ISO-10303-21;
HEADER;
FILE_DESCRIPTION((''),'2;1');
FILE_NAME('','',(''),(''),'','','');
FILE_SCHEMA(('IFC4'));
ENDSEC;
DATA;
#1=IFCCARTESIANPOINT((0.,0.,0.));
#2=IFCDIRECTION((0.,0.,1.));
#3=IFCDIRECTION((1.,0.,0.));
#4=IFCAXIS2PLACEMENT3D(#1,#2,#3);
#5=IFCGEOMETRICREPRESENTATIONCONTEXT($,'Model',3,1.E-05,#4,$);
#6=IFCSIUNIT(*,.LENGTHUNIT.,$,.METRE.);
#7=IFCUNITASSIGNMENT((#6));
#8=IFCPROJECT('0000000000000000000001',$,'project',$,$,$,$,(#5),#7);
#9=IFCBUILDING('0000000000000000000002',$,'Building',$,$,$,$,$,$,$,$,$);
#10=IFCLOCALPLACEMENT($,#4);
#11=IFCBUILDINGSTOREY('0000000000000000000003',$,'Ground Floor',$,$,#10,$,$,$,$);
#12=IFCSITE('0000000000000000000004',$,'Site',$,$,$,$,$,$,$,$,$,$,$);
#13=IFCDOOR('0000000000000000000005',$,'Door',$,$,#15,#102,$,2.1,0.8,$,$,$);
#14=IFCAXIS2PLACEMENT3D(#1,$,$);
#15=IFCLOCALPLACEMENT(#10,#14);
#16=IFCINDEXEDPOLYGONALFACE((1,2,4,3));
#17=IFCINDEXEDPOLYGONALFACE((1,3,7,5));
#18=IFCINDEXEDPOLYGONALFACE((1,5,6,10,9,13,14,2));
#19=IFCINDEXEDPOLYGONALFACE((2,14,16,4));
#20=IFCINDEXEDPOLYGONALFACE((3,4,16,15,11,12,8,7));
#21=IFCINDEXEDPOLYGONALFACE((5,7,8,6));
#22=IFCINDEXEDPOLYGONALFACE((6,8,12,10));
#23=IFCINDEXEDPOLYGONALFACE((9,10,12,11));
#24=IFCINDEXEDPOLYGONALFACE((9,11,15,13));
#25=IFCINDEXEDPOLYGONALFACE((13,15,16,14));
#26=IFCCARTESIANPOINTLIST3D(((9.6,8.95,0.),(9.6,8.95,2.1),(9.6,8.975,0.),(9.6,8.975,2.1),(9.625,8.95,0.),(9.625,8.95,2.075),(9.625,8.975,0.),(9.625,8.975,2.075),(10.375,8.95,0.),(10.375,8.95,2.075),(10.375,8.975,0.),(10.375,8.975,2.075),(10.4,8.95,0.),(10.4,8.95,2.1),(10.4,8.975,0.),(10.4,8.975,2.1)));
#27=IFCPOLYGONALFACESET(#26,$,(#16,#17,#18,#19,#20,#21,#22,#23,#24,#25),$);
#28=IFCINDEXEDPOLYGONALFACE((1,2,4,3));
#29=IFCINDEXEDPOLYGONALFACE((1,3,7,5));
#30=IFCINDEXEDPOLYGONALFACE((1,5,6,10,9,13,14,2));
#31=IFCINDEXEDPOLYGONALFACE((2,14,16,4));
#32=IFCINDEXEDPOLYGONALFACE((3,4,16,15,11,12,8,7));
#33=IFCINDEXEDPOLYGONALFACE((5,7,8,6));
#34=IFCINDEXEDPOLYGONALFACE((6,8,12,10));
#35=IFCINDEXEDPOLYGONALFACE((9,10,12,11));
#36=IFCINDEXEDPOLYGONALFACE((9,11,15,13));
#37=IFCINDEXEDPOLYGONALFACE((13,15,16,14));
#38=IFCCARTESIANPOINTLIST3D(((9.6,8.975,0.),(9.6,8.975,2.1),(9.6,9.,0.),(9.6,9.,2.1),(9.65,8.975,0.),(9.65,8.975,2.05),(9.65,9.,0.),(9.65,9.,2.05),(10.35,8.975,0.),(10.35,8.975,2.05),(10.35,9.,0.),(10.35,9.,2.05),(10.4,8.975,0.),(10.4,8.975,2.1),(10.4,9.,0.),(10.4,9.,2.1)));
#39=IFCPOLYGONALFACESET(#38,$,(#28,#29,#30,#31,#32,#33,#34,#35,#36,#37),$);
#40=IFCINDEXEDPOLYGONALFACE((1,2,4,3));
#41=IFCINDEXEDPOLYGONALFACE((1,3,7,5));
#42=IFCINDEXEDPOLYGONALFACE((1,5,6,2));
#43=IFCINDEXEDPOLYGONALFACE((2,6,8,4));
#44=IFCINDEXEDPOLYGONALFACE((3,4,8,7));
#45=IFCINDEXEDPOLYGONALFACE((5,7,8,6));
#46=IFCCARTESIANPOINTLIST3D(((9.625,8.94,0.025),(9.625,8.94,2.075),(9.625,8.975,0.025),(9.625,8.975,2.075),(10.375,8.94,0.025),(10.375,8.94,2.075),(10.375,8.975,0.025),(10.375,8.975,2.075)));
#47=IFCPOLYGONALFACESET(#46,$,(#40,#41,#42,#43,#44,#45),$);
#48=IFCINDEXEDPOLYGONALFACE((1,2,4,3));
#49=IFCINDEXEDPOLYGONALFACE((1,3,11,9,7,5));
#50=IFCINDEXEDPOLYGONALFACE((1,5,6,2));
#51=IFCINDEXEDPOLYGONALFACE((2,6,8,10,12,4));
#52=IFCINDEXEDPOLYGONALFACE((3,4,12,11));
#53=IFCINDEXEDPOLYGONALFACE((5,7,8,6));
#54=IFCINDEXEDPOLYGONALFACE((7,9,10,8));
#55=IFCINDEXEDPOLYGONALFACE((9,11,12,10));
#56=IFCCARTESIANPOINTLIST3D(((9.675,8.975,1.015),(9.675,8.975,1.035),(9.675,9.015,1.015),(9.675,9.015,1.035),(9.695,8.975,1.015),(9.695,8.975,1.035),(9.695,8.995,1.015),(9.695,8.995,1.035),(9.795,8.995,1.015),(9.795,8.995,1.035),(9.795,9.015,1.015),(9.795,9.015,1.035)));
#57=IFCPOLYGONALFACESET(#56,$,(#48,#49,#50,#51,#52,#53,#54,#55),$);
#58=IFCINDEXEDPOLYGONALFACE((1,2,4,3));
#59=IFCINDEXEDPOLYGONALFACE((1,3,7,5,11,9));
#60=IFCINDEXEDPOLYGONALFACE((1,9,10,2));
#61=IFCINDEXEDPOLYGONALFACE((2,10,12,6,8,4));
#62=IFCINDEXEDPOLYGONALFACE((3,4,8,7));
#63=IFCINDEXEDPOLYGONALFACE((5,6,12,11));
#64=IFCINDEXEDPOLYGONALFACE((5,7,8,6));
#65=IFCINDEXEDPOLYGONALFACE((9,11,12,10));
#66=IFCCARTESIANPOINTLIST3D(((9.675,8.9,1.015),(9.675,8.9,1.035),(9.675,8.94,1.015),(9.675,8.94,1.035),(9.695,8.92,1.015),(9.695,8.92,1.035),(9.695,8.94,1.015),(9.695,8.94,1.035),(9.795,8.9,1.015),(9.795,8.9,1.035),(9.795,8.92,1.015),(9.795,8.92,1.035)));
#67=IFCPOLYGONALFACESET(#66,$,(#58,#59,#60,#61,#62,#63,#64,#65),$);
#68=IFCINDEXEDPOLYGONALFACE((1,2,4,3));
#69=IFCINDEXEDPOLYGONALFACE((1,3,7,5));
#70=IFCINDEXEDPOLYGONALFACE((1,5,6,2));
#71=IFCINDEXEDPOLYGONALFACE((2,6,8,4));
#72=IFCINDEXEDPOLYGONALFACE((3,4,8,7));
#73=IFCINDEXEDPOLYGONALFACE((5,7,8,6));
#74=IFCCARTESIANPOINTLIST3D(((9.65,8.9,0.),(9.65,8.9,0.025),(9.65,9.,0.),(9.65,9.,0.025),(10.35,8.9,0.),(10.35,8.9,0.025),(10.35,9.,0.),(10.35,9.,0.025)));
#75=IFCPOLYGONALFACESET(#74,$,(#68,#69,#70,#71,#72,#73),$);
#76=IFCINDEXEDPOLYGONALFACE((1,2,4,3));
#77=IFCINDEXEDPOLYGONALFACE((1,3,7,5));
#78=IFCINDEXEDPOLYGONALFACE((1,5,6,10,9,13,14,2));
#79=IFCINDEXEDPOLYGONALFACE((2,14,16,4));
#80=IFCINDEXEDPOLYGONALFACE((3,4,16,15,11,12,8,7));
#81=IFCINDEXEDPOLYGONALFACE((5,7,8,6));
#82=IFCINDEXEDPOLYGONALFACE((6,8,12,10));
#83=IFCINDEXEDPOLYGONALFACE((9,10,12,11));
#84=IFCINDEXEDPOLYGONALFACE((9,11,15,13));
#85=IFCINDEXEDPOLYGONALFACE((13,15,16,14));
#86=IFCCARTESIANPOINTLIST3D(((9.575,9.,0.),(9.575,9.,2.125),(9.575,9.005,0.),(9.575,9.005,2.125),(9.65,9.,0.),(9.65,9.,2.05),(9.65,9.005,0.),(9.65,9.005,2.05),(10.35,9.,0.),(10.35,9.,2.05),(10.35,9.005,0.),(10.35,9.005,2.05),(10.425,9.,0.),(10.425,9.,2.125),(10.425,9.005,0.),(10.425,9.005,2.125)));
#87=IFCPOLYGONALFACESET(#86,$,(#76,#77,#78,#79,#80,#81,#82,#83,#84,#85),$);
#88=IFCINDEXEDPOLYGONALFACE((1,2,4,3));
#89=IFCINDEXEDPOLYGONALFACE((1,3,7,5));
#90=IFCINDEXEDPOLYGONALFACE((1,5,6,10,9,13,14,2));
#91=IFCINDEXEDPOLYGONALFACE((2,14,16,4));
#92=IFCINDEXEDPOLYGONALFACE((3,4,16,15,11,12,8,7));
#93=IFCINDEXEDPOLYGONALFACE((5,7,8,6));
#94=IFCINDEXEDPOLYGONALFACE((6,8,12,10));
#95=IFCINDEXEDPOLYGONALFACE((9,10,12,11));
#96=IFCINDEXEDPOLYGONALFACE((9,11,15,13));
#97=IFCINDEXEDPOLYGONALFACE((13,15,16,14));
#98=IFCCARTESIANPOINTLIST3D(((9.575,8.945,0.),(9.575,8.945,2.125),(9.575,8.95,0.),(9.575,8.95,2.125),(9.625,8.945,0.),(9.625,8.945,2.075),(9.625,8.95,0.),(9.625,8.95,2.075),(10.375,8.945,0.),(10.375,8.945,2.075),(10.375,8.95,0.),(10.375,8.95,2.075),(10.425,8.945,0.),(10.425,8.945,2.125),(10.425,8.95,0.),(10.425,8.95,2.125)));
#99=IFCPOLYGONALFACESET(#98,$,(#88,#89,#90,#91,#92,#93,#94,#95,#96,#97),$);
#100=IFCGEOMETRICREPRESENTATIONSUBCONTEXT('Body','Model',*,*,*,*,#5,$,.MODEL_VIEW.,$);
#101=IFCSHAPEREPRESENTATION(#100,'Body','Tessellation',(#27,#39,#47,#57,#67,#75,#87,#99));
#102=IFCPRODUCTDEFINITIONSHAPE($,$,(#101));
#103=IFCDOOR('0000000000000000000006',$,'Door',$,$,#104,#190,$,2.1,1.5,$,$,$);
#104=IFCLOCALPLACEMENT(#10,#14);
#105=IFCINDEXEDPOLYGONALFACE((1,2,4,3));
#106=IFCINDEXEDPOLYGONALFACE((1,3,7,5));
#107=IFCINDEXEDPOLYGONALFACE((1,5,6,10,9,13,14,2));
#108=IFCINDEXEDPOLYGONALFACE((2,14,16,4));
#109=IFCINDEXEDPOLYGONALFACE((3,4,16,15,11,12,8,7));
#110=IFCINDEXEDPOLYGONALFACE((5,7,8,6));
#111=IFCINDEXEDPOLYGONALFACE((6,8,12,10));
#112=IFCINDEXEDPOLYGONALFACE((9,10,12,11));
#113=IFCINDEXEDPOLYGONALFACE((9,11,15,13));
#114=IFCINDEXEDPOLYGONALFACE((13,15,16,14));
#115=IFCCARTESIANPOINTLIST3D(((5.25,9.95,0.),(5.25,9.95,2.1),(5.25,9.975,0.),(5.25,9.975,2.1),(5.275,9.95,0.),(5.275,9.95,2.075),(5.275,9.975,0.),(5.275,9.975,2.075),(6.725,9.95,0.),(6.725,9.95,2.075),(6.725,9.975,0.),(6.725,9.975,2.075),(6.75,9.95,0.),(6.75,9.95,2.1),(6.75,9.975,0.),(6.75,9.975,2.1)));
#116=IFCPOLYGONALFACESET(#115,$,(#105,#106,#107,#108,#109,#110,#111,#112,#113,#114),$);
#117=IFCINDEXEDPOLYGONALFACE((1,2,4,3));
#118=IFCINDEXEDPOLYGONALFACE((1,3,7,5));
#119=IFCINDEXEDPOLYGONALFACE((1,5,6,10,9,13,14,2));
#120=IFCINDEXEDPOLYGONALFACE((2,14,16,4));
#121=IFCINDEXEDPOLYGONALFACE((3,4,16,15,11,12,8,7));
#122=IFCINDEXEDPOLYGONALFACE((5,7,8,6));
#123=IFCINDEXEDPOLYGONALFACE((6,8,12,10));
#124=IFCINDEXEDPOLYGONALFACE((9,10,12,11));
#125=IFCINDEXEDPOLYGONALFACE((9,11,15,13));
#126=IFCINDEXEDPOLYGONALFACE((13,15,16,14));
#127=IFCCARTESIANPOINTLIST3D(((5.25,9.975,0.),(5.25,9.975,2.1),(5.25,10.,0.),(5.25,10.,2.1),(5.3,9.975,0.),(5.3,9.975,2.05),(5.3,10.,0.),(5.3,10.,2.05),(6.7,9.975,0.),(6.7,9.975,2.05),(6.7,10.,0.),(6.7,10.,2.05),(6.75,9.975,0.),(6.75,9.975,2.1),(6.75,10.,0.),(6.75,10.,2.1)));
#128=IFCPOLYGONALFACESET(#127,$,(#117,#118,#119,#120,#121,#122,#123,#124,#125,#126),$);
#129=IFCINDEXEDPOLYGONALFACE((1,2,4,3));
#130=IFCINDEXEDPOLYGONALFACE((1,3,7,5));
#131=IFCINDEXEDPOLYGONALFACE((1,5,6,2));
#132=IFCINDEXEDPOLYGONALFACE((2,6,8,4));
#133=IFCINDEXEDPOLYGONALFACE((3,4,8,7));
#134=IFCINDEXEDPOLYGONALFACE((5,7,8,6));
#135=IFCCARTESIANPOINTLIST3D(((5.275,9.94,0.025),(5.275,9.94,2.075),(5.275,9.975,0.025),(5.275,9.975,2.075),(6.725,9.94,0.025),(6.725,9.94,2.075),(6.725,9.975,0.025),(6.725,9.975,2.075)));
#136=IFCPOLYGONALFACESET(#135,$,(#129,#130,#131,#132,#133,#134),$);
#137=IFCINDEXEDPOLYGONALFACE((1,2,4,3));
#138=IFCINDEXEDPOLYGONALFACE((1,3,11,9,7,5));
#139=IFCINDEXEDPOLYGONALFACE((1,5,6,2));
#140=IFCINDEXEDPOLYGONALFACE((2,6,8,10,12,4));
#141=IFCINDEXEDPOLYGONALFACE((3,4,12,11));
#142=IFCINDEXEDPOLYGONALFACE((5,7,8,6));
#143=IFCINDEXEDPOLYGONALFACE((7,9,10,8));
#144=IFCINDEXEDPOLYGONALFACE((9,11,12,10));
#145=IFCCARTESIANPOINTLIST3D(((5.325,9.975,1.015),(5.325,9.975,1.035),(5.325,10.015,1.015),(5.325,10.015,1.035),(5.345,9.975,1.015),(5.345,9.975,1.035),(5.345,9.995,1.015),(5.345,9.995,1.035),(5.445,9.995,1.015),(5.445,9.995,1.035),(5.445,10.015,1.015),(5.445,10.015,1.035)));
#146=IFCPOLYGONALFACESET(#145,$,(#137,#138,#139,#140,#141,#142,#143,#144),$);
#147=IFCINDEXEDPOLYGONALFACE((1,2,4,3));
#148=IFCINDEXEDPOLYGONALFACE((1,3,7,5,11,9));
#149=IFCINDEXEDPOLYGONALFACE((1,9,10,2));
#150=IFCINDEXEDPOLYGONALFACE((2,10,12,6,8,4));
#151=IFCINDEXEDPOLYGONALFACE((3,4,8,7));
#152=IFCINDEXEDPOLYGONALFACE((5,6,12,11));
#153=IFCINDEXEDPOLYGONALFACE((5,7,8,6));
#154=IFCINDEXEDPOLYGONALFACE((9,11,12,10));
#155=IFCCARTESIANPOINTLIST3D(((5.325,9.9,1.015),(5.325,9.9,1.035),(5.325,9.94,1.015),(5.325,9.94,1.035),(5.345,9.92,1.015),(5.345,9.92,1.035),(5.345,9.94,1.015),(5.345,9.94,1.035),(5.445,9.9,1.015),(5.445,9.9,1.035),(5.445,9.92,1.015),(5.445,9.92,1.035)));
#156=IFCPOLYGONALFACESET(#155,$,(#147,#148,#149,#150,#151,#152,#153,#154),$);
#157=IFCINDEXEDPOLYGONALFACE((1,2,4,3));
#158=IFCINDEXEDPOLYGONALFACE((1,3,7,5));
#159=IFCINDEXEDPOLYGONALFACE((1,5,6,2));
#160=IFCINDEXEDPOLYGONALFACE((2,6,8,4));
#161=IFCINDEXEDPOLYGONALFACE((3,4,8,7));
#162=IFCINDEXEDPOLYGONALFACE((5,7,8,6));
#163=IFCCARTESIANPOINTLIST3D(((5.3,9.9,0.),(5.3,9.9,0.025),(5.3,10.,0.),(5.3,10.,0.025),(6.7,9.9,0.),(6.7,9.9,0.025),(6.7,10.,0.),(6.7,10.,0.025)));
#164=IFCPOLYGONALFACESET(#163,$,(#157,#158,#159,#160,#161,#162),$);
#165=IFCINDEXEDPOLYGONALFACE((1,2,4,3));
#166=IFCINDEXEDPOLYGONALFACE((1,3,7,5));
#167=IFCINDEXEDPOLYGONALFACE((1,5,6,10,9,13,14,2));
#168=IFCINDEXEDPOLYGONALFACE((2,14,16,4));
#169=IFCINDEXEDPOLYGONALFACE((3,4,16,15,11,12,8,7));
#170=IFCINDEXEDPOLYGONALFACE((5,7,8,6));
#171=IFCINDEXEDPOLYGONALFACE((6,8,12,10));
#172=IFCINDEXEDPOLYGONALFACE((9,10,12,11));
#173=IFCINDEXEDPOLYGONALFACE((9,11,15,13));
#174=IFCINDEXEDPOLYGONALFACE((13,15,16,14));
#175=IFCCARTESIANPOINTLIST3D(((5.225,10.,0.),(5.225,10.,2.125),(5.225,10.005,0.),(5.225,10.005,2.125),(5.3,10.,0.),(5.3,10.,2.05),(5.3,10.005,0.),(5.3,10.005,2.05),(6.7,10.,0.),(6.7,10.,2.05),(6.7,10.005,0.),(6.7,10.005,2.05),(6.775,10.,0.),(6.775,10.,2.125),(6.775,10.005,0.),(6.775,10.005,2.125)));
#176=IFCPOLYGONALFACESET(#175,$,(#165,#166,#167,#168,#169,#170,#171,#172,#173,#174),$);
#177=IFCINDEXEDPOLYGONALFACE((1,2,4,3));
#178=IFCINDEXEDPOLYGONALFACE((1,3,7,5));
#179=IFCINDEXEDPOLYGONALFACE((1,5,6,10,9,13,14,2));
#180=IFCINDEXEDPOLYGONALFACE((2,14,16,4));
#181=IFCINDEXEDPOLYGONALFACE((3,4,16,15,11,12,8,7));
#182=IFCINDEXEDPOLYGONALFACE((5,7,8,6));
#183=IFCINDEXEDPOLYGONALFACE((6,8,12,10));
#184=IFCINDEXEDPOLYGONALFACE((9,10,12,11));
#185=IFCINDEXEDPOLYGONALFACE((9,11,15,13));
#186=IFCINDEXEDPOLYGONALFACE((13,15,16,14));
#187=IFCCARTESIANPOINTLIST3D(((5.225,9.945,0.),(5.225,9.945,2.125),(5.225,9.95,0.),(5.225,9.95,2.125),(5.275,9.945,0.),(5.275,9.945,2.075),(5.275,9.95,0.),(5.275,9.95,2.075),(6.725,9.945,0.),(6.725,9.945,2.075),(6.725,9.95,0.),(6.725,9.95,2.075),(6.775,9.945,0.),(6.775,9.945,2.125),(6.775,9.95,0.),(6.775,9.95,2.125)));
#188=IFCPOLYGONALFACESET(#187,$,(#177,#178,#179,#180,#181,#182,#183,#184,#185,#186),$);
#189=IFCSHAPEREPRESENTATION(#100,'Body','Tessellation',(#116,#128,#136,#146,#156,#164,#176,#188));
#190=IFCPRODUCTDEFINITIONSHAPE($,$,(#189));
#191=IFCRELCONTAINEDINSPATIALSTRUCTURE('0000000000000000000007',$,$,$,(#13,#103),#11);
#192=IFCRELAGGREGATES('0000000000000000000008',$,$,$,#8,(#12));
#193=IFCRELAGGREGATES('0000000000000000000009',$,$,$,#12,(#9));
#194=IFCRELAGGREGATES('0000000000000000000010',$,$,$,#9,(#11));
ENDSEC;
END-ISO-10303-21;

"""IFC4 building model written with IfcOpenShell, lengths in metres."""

from ifc_helpers import new_model, si_unit, frame, origin_with_axes, place, context, subcontext, project, spatial, line, indexed_curve, outline, extrude, element, save


model = new_model("IFC4")

# Units and contexts
model_context = context("Model", 3, precision=1e-05, world=origin_with_axes())
body_context = subcontext(model_context, "Body", "Model", "MODEL_VIEW")
ifc_project = project(units=[si_unit("LENGTHUNIT", "METRE")], contexts=[model_context])

# Site, building, storey
site = spatial("IfcSite", under=ifc_project, Name="Site")
building = spatial("IfcBuilding", under=site, Name="Building")
storey_placement = place(None, origin_with_axes())
storey = spatial("IfcBuildingStorey", under=building, at=storey_placement, Name="Ground Floor")

# Doors
door_1_placement = place(storey_placement, frame((10.4, 9.0, 0.0), z_axis=(0.0, 0.0, 1.0), x_axis=(-1.0, 0.0, 0.0)))
element("IfcDoor", 1, at=door_1_placement, inside=storey, Name="Door", OverallHeight=2.1, OverallWidth=0.8, context=body_context, shape_type="SweptSolid", body=[
    extrude(outline(indexed_curve([(0.0, 0.0), (0.0, 2.1), (0.8, 2.1), (0.8, 0.0), (0.775, 0.0), (0.775, 2.075), (0.025, 2.075), (0.025, 0.0)], segments=[line(1, 2, 3, 4, 5, 6, 7, 8, 1)])), frame((0.0, 0.025, 0.0), z_axis=(0.0, -1.0, 0.0), x_axis=(1.0, 0.0, 0.0)), (0.0, 0.0, -1.0), 0.025),
    extrude(outline(indexed_curve([(0.0, 0.0), (0.0, 2.1), (0.8, 2.1), (0.8, 0.0), (0.75, 0.0), (0.75, 2.05), (0.05, 2.05), (0.05, 0.0)], segments=[line(1, 2, 3, 4, 5, 6, 7, 8, 1)])), frame((0.0, 0.0, 0.0), z_axis=(0.0, -1.0, 0.0), x_axis=(1.0, 0.0, 0.0)), (0.0, 0.0, -1.0), 0.025),
    extrude(outline(indexed_curve([(0.0, 0.0), (0.75, 0.0), (0.75, 0.035), (0.0, 0.035)], segments=[line(1, 2, 3, 4, 1)])), frame((0.025, 0.025, 0.025), z_axis=(0.0, 0.0, 1.0), x_axis=(1.0, 0.0, 0.0)), (0.0, 0.0, 1.0), 2.05),
    extrude(outline(indexed_curve([(0.0, 0.0), (0.0, -0.04), (-0.12, -0.04), (-0.12, -0.02), (-0.02, -0.02), (-0.02, 0.0)], segments=[line(1, 2, 3, 4, 5, 6, 1)])), frame((0.725, 0.025, 1.015), z_axis=(0.0, 0.0, 1.0), x_axis=(1.0, 0.0, 0.0)), (0.0, 0.0, 1.0), 0.02),
    extrude(outline(indexed_curve([(0.0, 0.0), (0.0, 0.04), (-0.12, 0.04), (-0.12, 0.02), (-0.02, 0.02), (-0.02, 0.0)], segments=[line(1, 2, 3, 4, 5, 6, 1)])), frame((0.725, 0.06, 1.015), z_axis=(0.0, 0.0, 1.0), x_axis=(1.0, 0.0, 0.0)), (0.0, 0.0, 1.0), 0.02),
    extrude(outline(indexed_curve([(0.0, 0.0), (0.7, 0.0), (0.7, 0.1), (0.0, 0.1)], segments=[line(1, 2, 3, 4, 1)])), frame((0.05, 0.0, 0.0), z_axis=(0.0, 0.0, 1.0), x_axis=(1.0, 0.0, 0.0)), (0.0, 0.0, 1.0), 0.025),
    extrude(outline(indexed_curve([(0.0, 0.0), (0.0, 2.125), (0.85, 2.125), (0.85, 0.0), (0.775, 0.0), (0.775, 2.05), (0.075, 2.05), (0.075, 0.0)], segments=[line(1, 2, 3, 4, 5, 6, 7, 8, 1)])), frame((-0.025, -0.005, 0.0), z_axis=(0.0, -1.0, 0.0), x_axis=(1.0, 0.0, 0.0)), (0.0, 0.0, -1.0), 0.005),
    extrude(outline(indexed_curve([(0.0, 0.0), (0.0, 2.125), (0.85, 2.125), (0.85, 0.0), (0.8, 0.0), (0.8, 2.075), (0.05, 2.075), (0.05, 0.0)], segments=[line(1, 2, 3, 4, 5, 6, 7, 8, 1)])), frame((-0.025, 0.05, 0.0), z_axis=(0.0, -1.0, 0.0), x_axis=(1.0, 0.0, 0.0)), (0.0, 0.0, -1.0), 0.005),
])
door_2_placement = place(storey_placement, frame((6.75, 10.0, 0.0), z_axis=(0.0, 0.0, 1.0), x_axis=(-1.0, 0.0, 0.0)))
element("IfcDoor", 2, at=door_2_placement, inside=storey, Name="Door", OverallHeight=2.1, OverallWidth=1.5, context=body_context, shape_type="SweptSolid", body=[
    extrude(outline(indexed_curve([(0.0, 0.0), (0.0, 2.1), (1.5, 2.1), (1.5, 0.0), (1.475, 0.0), (1.475, 2.075), (0.025, 2.075), (0.025, 0.0)], segments=[line(1, 2, 3, 4, 5, 6, 7, 8, 1)])), frame((0.0, 0.025, 0.0), z_axis=(0.0, -1.0, 0.0), x_axis=(1.0, 0.0, 0.0)), (0.0, 0.0, -1.0), 0.025),
    extrude(outline(indexed_curve([(0.0, 0.0), (0.0, 2.1), (1.5, 2.1), (1.5, 0.0), (1.45, 0.0), (1.45, 2.05), (0.05, 2.05), (0.05, 0.0)], segments=[line(1, 2, 3, 4, 5, 6, 7, 8, 1)])), frame((0.0, 0.0, 0.0), z_axis=(0.0, -1.0, 0.0), x_axis=(1.0, 0.0, 0.0)), (0.0, 0.0, -1.0), 0.025),
    extrude(outline(indexed_curve([(0.0, 0.0), (1.45, 0.0), (1.45, 0.035), (0.0, 0.035)], segments=[line(1, 2, 3, 4, 1)])), frame((0.025, 0.025, 0.025), z_axis=(0.0, 0.0, 1.0), x_axis=(1.0, 0.0, 0.0)), (0.0, 0.0, 1.0), 2.05),
    extrude(outline(indexed_curve([(0.0, 0.0), (0.0, -0.04), (-0.12, -0.04), (-0.12, -0.02), (-0.02, -0.02), (-0.02, 0.0)], segments=[line(1, 2, 3, 4, 5, 6, 1)])), frame((1.425, 0.025, 1.015), z_axis=(0.0, 0.0, 1.0), x_axis=(1.0, 0.0, 0.0)), (0.0, 0.0, 1.0), 0.02),
    extrude(outline(indexed_curve([(0.0, 0.0), (0.0, 0.04), (-0.12, 0.04), (-0.12, 0.02), (-0.02, 0.02), (-0.02, 0.0)], segments=[line(1, 2, 3, 4, 5, 6, 1)])), frame((1.425, 0.06, 1.015), z_axis=(0.0, 0.0, 1.0), x_axis=(1.0, 0.0, 0.0)), (0.0, 0.0, 1.0), 0.02),
    extrude(outline(indexed_curve([(0.0, 0.0), (1.4, 0.0), (1.4, 0.1), (0.0, 0.1)], segments=[line(1, 2, 3, 4, 1)])), frame((0.05, 0.0, 0.0), z_axis=(0.0, 0.0, 1.0), x_axis=(1.0, 0.0, 0.0)), (0.0, 0.0, 1.0), 0.025),
    extrude(outline(indexed_curve([(0.0, 0.0), (0.0, 2.125), (1.55, 2.125), (1.55, 0.0), (1.475, 0.0), (1.475, 2.05), (0.075, 2.05), (0.075, 0.0)], segments=[line(1, 2, 3, 4, 5, 6, 7, 8, 1)])), frame((-0.025, -0.005, 0.0), z_axis=(0.0, -1.0, 0.0), x_axis=(1.0, 0.0, 0.0)), (0.0, 0.0, -1.0), 0.005),
    extrude(outline(indexed_curve([(0.0, 0.0), (0.0, 2.125), (1.55, 2.125), (1.55, 0.0), (1.5, 0.0), (1.5, 2.075), (0.05, 2.075), (0.05, 0.0)], segments=[line(1, 2, 3, 4, 5, 6, 7, 8, 1)])), frame((-0.025, 0.05, 0.0), z_axis=(0.0, -1.0, 0.0), x_axis=(1.0, 0.0, 0.0)), (0.0, 0.0, -1.0), 0.005),
])

save(model, "model.ifc")
